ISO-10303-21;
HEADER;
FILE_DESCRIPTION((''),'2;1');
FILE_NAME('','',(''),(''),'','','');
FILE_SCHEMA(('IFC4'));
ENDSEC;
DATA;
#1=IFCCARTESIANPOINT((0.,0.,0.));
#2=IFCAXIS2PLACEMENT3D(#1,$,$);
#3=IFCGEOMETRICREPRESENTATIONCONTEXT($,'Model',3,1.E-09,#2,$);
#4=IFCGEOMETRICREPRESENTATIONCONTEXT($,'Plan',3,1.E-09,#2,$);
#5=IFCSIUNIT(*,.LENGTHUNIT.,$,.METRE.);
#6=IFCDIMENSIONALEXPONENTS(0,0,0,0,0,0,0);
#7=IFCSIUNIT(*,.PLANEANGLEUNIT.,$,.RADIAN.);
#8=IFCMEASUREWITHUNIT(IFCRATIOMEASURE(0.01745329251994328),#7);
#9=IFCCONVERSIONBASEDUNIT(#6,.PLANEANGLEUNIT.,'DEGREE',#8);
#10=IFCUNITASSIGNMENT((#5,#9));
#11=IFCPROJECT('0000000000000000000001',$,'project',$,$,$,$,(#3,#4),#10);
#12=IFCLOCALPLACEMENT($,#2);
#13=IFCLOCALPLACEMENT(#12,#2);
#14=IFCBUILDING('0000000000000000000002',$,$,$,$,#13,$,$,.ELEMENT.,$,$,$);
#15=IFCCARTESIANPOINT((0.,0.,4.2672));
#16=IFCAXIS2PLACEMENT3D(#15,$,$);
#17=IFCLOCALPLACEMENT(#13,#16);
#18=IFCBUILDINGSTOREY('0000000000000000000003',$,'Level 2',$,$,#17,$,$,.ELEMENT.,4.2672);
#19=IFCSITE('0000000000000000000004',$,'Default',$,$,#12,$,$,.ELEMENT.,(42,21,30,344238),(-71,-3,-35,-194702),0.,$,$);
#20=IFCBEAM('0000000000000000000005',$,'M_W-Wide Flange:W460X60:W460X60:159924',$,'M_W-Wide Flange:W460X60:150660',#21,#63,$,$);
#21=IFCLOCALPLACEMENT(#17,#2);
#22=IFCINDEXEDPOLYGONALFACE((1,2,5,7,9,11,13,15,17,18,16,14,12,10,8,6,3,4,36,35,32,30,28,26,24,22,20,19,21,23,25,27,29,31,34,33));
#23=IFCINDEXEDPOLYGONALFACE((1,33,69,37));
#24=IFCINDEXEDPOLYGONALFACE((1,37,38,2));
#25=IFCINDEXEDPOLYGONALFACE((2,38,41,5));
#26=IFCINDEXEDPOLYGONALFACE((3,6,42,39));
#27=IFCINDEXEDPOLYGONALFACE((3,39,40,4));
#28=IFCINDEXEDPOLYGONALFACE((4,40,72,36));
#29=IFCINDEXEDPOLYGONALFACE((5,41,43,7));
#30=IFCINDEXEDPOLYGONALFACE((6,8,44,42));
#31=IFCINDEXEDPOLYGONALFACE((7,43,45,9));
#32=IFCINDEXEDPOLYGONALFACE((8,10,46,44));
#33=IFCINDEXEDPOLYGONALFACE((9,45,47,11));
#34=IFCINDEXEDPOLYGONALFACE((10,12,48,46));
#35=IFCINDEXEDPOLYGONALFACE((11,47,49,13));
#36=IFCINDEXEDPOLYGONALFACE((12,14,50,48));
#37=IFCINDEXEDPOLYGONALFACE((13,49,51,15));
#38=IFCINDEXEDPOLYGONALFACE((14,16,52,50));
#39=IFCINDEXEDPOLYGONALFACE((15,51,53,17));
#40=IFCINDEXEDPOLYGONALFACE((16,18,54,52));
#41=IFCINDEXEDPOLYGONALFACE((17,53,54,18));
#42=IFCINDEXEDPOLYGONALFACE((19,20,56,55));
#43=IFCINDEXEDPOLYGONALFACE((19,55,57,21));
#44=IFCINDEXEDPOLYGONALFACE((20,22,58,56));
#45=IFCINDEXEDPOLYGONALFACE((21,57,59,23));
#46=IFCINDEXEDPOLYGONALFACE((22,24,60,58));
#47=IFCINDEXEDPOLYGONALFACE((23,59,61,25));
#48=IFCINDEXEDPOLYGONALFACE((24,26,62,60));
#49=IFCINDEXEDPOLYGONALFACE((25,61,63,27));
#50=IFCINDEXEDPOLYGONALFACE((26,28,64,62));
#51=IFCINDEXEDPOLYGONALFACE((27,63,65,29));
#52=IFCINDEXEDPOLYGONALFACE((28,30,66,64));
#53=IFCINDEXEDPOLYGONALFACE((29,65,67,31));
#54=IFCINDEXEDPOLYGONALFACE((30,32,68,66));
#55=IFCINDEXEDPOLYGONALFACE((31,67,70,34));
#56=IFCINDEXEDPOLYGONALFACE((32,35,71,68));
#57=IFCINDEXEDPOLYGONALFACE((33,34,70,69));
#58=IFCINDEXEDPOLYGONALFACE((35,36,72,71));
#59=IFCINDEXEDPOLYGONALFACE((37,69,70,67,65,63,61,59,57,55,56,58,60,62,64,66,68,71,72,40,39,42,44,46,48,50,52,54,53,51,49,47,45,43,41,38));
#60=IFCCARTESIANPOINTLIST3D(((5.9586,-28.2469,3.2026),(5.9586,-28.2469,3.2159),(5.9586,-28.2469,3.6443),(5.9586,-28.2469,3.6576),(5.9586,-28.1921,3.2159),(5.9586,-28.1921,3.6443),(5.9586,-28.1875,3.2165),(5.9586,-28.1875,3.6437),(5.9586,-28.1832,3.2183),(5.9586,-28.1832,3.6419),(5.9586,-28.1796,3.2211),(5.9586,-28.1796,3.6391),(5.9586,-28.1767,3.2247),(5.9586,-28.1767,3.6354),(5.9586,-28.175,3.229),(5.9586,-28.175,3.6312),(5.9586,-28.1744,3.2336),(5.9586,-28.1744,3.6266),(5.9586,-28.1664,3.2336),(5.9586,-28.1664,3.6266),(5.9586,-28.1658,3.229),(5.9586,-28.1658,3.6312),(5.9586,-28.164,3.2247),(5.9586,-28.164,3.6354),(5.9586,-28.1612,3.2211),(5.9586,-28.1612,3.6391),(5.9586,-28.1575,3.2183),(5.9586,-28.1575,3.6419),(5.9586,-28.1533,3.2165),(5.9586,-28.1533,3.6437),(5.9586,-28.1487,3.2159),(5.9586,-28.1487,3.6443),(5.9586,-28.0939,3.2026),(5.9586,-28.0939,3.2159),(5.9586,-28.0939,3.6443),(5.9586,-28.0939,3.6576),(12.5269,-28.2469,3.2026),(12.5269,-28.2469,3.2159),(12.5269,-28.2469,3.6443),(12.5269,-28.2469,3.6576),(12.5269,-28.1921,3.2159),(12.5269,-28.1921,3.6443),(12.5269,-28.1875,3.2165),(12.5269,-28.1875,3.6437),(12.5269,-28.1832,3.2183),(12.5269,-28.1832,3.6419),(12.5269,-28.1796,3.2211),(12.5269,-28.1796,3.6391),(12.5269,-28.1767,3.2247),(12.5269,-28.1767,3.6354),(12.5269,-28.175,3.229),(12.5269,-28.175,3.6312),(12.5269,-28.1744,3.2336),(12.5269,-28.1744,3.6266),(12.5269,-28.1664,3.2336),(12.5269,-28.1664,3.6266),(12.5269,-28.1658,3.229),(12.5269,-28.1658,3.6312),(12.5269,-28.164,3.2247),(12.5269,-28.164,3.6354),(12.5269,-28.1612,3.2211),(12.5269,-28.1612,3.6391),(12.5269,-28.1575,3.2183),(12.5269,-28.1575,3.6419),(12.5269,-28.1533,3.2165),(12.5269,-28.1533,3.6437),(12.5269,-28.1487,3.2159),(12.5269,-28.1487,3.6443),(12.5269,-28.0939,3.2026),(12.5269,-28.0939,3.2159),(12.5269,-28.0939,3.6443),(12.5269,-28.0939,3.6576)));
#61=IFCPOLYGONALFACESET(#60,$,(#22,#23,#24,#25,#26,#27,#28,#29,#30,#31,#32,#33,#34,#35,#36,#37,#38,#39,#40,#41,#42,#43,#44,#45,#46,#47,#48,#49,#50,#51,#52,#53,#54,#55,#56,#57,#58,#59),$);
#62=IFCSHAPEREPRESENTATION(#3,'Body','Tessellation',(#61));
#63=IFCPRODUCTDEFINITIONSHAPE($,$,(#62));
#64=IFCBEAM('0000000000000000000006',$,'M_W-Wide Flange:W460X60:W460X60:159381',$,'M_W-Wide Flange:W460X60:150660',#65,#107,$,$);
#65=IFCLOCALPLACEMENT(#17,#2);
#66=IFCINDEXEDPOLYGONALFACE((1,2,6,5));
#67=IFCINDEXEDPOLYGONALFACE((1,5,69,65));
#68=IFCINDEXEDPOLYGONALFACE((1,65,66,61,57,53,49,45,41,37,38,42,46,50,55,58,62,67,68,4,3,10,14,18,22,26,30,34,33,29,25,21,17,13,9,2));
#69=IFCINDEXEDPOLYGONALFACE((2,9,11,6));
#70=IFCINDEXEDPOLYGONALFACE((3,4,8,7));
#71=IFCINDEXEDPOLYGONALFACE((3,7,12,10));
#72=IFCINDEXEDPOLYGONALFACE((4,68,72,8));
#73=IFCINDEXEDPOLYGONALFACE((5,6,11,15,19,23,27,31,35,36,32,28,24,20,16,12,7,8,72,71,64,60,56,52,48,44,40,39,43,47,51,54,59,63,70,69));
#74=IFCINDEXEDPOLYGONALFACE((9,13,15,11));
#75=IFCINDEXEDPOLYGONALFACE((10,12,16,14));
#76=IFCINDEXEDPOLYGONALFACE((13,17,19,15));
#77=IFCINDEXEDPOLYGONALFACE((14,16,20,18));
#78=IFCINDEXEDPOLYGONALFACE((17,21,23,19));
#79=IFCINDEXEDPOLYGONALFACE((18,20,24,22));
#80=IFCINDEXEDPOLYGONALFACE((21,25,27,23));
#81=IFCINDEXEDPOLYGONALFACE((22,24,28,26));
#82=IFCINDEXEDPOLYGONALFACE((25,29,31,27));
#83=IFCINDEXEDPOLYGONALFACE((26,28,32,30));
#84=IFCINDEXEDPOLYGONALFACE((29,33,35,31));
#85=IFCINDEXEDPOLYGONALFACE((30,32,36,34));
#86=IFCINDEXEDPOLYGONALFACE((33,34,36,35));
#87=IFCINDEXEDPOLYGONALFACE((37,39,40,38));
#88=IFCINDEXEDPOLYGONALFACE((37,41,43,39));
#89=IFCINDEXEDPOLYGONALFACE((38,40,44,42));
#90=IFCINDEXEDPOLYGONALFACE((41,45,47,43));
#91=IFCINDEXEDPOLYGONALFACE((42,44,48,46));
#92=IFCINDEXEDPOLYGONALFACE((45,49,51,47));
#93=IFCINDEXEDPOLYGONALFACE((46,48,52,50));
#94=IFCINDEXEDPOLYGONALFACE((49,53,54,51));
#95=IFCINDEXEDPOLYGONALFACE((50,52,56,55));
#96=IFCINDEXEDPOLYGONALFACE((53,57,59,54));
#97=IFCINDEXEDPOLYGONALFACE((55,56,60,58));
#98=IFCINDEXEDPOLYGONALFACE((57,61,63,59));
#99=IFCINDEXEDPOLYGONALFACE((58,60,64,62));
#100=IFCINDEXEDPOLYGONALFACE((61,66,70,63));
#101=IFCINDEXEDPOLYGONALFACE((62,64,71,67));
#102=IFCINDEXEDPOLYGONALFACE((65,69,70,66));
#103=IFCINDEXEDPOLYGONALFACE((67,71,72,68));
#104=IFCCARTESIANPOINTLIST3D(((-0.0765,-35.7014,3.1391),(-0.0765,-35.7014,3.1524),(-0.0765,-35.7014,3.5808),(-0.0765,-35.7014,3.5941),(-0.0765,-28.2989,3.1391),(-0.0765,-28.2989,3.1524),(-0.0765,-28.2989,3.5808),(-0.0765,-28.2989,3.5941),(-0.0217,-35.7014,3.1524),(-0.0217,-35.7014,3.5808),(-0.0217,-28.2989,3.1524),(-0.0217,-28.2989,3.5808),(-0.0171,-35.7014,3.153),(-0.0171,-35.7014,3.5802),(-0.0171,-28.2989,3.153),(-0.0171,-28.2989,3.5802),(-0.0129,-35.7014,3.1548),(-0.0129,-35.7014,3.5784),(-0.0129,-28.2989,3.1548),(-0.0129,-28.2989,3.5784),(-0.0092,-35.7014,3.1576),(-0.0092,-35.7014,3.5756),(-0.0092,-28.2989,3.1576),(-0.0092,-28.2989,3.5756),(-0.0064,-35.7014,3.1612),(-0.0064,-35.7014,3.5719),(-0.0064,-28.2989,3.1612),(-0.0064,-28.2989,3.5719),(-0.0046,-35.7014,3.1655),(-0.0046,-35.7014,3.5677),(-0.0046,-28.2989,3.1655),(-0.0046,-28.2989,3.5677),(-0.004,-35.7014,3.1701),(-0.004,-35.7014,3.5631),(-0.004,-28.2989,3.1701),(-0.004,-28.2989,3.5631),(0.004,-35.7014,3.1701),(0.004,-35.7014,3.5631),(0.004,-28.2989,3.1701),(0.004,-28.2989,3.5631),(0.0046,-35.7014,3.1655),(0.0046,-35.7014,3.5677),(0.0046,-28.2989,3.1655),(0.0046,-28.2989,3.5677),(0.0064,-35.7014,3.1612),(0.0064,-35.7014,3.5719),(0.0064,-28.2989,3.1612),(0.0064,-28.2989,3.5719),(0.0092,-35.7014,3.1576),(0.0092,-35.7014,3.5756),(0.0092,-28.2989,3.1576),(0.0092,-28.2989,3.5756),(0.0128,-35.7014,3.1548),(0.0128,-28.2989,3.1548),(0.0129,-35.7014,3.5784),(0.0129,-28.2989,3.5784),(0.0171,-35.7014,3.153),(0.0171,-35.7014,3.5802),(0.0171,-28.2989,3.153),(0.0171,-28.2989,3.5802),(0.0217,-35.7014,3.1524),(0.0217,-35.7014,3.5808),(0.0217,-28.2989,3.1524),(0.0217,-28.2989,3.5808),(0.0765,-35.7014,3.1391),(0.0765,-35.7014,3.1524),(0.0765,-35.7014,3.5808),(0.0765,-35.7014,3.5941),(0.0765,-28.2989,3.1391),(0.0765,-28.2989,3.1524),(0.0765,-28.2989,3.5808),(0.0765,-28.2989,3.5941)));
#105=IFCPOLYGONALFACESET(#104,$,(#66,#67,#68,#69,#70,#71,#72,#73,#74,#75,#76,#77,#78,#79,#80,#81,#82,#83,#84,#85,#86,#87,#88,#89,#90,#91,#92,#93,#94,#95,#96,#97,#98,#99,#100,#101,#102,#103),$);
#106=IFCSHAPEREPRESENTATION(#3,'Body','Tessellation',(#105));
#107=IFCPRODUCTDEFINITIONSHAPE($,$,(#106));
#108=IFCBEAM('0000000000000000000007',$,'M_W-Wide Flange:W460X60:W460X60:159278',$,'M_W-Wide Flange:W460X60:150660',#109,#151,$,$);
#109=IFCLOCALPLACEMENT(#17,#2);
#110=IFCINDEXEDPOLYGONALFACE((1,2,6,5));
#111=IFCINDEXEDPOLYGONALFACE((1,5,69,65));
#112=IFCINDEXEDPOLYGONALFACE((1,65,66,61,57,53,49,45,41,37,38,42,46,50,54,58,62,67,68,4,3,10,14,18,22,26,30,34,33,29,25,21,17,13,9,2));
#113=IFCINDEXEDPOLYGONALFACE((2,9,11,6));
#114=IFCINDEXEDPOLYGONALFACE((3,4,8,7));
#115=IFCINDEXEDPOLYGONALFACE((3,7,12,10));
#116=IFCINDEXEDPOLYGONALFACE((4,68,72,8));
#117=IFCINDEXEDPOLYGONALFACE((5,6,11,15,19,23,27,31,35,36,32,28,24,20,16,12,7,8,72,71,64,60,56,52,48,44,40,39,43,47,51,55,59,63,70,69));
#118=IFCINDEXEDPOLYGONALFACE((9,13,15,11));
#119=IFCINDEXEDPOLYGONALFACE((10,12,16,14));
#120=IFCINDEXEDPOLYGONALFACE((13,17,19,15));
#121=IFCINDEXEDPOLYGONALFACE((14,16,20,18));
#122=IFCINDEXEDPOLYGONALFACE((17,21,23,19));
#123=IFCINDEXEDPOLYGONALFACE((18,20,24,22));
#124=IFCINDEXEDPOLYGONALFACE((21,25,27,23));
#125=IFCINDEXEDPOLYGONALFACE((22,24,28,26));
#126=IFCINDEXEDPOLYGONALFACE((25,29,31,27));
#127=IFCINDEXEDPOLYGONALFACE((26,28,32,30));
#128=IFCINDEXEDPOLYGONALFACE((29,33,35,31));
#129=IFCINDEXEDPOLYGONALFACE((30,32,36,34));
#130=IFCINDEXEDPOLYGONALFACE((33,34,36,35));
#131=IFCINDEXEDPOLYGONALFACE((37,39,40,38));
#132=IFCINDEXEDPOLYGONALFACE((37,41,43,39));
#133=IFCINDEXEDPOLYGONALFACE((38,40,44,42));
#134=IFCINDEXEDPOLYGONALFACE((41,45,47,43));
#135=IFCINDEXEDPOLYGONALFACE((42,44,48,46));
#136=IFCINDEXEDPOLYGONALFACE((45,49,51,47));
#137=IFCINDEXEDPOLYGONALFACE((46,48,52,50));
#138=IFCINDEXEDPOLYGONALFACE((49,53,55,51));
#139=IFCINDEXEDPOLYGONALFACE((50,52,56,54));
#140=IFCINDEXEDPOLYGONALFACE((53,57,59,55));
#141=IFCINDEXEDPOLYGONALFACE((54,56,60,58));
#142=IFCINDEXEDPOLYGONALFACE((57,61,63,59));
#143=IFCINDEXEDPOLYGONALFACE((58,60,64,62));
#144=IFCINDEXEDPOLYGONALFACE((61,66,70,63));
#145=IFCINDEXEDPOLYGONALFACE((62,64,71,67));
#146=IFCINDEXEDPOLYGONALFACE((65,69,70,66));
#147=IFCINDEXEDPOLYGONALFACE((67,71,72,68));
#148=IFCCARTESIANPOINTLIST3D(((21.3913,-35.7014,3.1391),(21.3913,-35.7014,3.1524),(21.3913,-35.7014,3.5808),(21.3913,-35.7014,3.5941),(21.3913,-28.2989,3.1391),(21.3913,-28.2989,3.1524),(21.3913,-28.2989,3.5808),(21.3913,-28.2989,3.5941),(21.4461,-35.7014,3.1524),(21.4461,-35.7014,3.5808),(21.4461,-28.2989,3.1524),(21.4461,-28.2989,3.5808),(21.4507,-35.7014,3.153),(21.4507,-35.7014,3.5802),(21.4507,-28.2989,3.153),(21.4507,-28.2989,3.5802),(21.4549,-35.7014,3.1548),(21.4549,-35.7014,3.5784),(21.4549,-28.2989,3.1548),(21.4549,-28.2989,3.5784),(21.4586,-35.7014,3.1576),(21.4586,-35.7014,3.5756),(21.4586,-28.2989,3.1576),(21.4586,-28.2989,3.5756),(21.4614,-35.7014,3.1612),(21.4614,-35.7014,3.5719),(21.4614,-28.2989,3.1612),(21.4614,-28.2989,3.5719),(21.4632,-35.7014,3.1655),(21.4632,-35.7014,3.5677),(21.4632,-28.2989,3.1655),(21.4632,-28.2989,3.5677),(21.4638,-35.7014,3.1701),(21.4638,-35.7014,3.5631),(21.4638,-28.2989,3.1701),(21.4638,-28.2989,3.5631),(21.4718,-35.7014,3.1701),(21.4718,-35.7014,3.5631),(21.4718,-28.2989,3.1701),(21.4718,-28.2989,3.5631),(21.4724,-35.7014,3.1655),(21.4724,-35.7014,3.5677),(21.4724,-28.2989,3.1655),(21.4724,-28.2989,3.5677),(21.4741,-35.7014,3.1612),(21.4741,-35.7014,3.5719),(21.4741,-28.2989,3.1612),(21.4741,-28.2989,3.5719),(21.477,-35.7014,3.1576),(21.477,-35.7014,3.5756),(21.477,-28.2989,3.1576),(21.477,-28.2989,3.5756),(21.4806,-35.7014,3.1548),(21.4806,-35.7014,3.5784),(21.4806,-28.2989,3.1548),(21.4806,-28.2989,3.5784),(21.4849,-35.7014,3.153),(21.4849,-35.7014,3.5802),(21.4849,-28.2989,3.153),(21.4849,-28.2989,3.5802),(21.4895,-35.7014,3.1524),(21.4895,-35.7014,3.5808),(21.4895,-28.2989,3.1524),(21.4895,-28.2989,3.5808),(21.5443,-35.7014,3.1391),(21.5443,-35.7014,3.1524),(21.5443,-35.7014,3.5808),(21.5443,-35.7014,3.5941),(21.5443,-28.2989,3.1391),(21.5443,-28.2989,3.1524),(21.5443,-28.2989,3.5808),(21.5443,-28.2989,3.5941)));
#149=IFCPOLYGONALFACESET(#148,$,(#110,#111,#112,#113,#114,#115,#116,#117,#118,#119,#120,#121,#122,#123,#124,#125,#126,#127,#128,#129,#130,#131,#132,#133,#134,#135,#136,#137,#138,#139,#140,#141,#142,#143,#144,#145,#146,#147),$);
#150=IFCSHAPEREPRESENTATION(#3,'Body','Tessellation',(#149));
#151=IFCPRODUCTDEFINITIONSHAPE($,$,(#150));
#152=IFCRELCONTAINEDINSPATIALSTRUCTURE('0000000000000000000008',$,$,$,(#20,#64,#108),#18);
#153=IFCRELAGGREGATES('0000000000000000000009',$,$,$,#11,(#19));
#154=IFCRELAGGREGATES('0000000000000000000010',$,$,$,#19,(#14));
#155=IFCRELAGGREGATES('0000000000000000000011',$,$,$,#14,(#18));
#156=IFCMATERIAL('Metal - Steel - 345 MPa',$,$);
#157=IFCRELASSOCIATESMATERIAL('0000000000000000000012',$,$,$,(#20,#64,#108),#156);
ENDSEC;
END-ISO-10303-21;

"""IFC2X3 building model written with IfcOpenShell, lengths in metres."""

from ifc_helpers import new_model, entity, si_unit, converted_unit, frame, frame_2d, origin, place, context, project, spatial, polyline, circle_curve, parameter, trimmed, segment, composite_curve, outline, extrude, material, element, save


model = new_model("IFC2X3")

# Units and contexts
model_context = context("Model", 3, precision=1e-09, world=origin())
plan_context = context("Plan", 3, precision=1e-09, world=origin())
ifc_project = project(units=[si_unit("LENGTHUNIT", "METRE"), converted_unit("PLANEANGLEUNIT", "DEGREE", entity("IfcRatioMeasure", 0.01745329251994328), si_unit("PLANEANGLEUNIT", "RADIAN"), dimensions=[0, 0, 0, 0, 0, 0, 0])], contexts=[model_context, plan_context])

# Site, building, storey
site_placement = place(None, origin())
site = spatial("IfcSite", under=ifc_project, at=site_placement, Name="Default", CompositionType="ELEMENT", RefLatitude=(42, 21, 30, 344238), RefLongitude=(-71, -3, -35, -194702), RefElevation=0.0)
building_placement = place(site_placement, origin())
building = spatial("IfcBuilding", under=site, at=building_placement, CompositionType="ELEMENT")
storey_placement = place(building_placement, frame((0.0, 0.0, 4.2672)))
storey = spatial("IfcBuildingStorey", under=building, at=storey_placement, Name="Level 2", CompositionType="ELEMENT", Elevation=4.2672)

# Shared definitions
ifc_material_1 = material(Name="Metal - Steel - 345 MPa")

# Beams
beam_1_placement = place(storey_placement, frame((12.6289, -28.1704, 3.6576), z_axis=(0.0, 0.0, 1.0), x_axis=(0.0, 1.0, 0.0)))
element("IfcBeam", 1, at=beam_1_placement, inside=storey, material=ifc_material_1, Name="M_W-Wide Flange:W460X60:W460X60:159924", ObjectType="M_W-Wide Flange:W460X60:150660", context=model_context, shape_type="SweptSolid", body=[
    extrude(outline(composite_curve([segment(polyline([(0.2142, -0.0765), (0.2275, -0.0765)]), True, "CONTINUOUS"), segment(polyline([(0.2275, -0.0765), (0.2275, 0.0765)]), True, "CONTINUOUS"), segment(polyline([(0.2275, 0.0765), (0.2142, 0.0765)]), True, "CONTINUOUS"), segment(polyline([(0.2142, 0.0765), (0.2142, 0.0217)]), True, "CONTINUOUS"), segment(trimmed(circle_curve(frame_2d((0.1965, 0.0217), x_axis=(1.0, 0.0)), 0.0177), [parameter(270.0)], [parameter(360.0)], True, "PARAMETER"), False, "CONTINUOUS"), segment(polyline([(0.1965, 0.004), (-0.1965, 0.004)]), True, "CONTINUOUS"), segment(trimmed(circle_curve(frame_2d((-0.1965, 0.0217), x_axis=(0.0, -1.0)), 0.0177), [parameter(270.0)], [parameter(360.0)], True, "PARAMETER"), False, "CONTINUOUS"), segment(polyline([(-0.2142, 0.0217), (-0.2142, 0.0765)]), True, "CONTINUOUS"), segment(polyline([(-0.2142, 0.0765), (-0.2275, 0.0765)]), True, "CONTINUOUS"), segment(polyline([(-0.2275, 0.0765), (-0.2275, -0.0765)]), True, "CONTINUOUS"), segment(polyline([(-0.2275, -0.0765), (-0.2142, -0.0765)]), True, "CONTINUOUS"), segment(polyline([(-0.2142, -0.0765), (-0.2142, -0.0217)]), True, "CONTINUOUS"), segment(trimmed(circle_curve(frame_2d((-0.1965, -0.0217), x_axis=(-1.0, 0.0)), 0.0177), [parameter(270.0)], [parameter(360.0)], True, "PARAMETER"), False, "CONTINUOUS"), segment(polyline([(-0.1965, -0.004), (0.1965, -0.004)]), True, "CONTINUOUS"), segment(trimmed(circle_curve(frame_2d((0.1965, -0.0217), x_axis=(0.0, 1.0)), 0.0177), [parameter(270.0)], [parameter(0.0)], True, "PARAMETER"), False, "CONTINUOUS"), segment(polyline([(0.2142, -0.0217), (0.2142, -0.0765)]), True, "CONTINUOUS")], self_intersect=False)), frame((0.0, 6.6703, -0.2275), z_axis=(0.0, -1.0, 0.0), x_axis=(0.0, 0.0, -1.0)), (0.0, 0.0, 1.0), 6.5683),
])
beam_2_placement = place(storey_placement, frame((0.0, -35.8299, 3.6576)))
element("IfcBeam", 2, at=beam_2_placement, inside=storey, material=ifc_material_1, Name="M_W-Wide Flange:W460X60:W460X60:159381", ObjectType="M_W-Wide Flange:W460X60:150660", context=model_context, shape_type="SweptSolid", body=[
    extrude(outline(composite_curve([segment(polyline([(-0.0765, -0.2142), (-0.0765, -0.2275)]), True, "CONTINUOUS"), segment(polyline([(-0.0765, -0.2275), (0.0765, -0.2275)]), True, "CONTINUOUS"), segment(polyline([(0.0765, -0.2275), (0.0765, -0.2142)]), True, "CONTINUOUS"), segment(polyline([(0.0765, -0.2142), (0.0217, -0.2142)]), True, "CONTINUOUS"), segment(trimmed(circle_curve(frame_2d((0.0217, -0.1965), x_axis=(0.0, -1.0)), 0.0177), [parameter(270.0)], [parameter(360.0)], True, "PARAMETER"), False, "CONTINUOUS"), segment(polyline([(0.004, -0.1965), (0.004, 0.1965)]), True, "CONTINUOUS"), segment(trimmed(circle_curve(frame_2d((0.0217, 0.1965), x_axis=(-1.0, 0.0)), 0.0177), [parameter(270.0)], [parameter(360.0)], True, "PARAMETER"), False, "CONTINUOUS"), segment(polyline([(0.0217, 0.2142), (0.0765, 0.2142)]), True, "CONTINUOUS"), segment(polyline([(0.0765, 0.2142), (0.0765, 0.2275)]), True, "CONTINUOUS"), segment(polyline([(0.0765, 0.2275), (-0.0765, 0.2275)]), True, "CONTINUOUS"), segment(polyline([(-0.0765, 0.2275), (-0.0765, 0.2142)]), True, "CONTINUOUS"), segment(polyline([(-0.0765, 0.2142), (-0.0217, 0.2142)]), True, "CONTINUOUS"), segment(trimmed(circle_curve(frame_2d((-0.0217, 0.1965), x_axis=(0.0, 1.0)), 0.0177), [parameter(270.0)], [parameter(360.0)], True, "PARAMETER"), False, "CONTINUOUS"), segment(polyline([(-0.004, 0.1965), (-0.004, -0.1965)]), True, "CONTINUOUS"), segment(trimmed(circle_curve(frame_2d((-0.0217, -0.1965), x_axis=(1.0, 0.0)), 0.0177), [parameter(270.0)], [parameter(0.0)], True, "PARAMETER"), False, "CONTINUOUS"), segment(polyline([(-0.0217, -0.2142), (-0.0765, -0.2142)]), True, "CONTINUOUS")], self_intersect=False)), frame((0.0, 0.1285, -0.291), z_axis=(0.0, -1.0, 0.0), x_axis=(1.0, 0.0, 0.0)), (0.0, 0.0, -1.0), 7.4025),
])
beam_3_placement = place(storey_placement, frame((21.4678, -35.8299, 3.6576)))
element("IfcBeam", 3, at=beam_3_placement, inside=storey, material=ifc_material_1, Name="M_W-Wide Flange:W460X60:W460X60:159278", ObjectType="M_W-Wide Flange:W460X60:150660", context=model_context, shape_type="SweptSolid", body=[
    extrude(outline(composite_curve([segment(polyline([(-0.0765, -0.2142), (-0.0765, -0.2275)]), True, "CONTINUOUS"), segment(polyline([(-0.0765, -0.2275), (0.0765, -0.2275)]), True, "CONTINUOUS"), segment(polyline([(0.0765, -0.2275), (0.0765, -0.2142)]), True, "CONTINUOUS"), segment(polyline([(0.0765, -0.2142), (0.0217, -0.2142)]), True, "CONTINUOUS"), segment(trimmed(circle_curve(frame_2d((0.0217, -0.1965), x_axis=(0.0, -1.0)), 0.0177), [parameter(270.0)], [parameter(360.0)], True, "PARAMETER"), False, "CONTINUOUS"), segment(polyline([(0.004, -0.1965), (0.004, 0.1965)]), True, "CONTINUOUS"), segment(trimmed(circle_curve(frame_2d((0.0217, 0.1965), x_axis=(-1.0, 0.0)), 0.0177), [parameter(270.0)], [parameter(360.0)], True, "PARAMETER"), False, "CONTINUOUS"), segment(polyline([(0.0217, 0.2142), (0.0765, 0.2142)]), True, "CONTINUOUS"), segment(polyline([(0.0765, 0.2142), (0.0765, 0.2275)]), True, "CONTINUOUS"), segment(polyline([(0.0765, 0.2275), (-0.0765, 0.2275)]), True, "CONTINUOUS"), segment(polyline([(-0.0765, 0.2275), (-0.0765, 0.2142)]), True, "CONTINUOUS"), segment(polyline([(-0.0765, 0.2142), (-0.0217, 0.2142)]), True, "CONTINUOUS"), segment(trimmed(circle_curve(frame_2d((-0.0217, 0.1965), x_axis=(0.0, 1.0)), 0.0177), [parameter(270.0)], [parameter(360.0)], True, "PARAMETER"), False, "CONTINUOUS"), segment(polyline([(-0.004, 0.1965), (-0.004, -0.1965)]), True, "CONTINUOUS"), segment(trimmed(circle_curve(frame_2d((-0.0217, -0.1965), x_axis=(1.0, 0.0)), 0.0177), [parameter(270.0)], [parameter(0.0)], True, "PARAMETER"), False, "CONTINUOUS"), segment(polyline([(-0.0217, -0.2142), (-0.0765, -0.2142)]), True, "CONTINUOUS")], self_intersect=False)), frame((0.0, 0.1285, -0.291), z_axis=(0.0, -1.0, 0.0), x_axis=(1.0, 0.0, 0.0)), (0.0, 0.0, -1.0), 7.4025),
])

save(model, "model.ifc")
